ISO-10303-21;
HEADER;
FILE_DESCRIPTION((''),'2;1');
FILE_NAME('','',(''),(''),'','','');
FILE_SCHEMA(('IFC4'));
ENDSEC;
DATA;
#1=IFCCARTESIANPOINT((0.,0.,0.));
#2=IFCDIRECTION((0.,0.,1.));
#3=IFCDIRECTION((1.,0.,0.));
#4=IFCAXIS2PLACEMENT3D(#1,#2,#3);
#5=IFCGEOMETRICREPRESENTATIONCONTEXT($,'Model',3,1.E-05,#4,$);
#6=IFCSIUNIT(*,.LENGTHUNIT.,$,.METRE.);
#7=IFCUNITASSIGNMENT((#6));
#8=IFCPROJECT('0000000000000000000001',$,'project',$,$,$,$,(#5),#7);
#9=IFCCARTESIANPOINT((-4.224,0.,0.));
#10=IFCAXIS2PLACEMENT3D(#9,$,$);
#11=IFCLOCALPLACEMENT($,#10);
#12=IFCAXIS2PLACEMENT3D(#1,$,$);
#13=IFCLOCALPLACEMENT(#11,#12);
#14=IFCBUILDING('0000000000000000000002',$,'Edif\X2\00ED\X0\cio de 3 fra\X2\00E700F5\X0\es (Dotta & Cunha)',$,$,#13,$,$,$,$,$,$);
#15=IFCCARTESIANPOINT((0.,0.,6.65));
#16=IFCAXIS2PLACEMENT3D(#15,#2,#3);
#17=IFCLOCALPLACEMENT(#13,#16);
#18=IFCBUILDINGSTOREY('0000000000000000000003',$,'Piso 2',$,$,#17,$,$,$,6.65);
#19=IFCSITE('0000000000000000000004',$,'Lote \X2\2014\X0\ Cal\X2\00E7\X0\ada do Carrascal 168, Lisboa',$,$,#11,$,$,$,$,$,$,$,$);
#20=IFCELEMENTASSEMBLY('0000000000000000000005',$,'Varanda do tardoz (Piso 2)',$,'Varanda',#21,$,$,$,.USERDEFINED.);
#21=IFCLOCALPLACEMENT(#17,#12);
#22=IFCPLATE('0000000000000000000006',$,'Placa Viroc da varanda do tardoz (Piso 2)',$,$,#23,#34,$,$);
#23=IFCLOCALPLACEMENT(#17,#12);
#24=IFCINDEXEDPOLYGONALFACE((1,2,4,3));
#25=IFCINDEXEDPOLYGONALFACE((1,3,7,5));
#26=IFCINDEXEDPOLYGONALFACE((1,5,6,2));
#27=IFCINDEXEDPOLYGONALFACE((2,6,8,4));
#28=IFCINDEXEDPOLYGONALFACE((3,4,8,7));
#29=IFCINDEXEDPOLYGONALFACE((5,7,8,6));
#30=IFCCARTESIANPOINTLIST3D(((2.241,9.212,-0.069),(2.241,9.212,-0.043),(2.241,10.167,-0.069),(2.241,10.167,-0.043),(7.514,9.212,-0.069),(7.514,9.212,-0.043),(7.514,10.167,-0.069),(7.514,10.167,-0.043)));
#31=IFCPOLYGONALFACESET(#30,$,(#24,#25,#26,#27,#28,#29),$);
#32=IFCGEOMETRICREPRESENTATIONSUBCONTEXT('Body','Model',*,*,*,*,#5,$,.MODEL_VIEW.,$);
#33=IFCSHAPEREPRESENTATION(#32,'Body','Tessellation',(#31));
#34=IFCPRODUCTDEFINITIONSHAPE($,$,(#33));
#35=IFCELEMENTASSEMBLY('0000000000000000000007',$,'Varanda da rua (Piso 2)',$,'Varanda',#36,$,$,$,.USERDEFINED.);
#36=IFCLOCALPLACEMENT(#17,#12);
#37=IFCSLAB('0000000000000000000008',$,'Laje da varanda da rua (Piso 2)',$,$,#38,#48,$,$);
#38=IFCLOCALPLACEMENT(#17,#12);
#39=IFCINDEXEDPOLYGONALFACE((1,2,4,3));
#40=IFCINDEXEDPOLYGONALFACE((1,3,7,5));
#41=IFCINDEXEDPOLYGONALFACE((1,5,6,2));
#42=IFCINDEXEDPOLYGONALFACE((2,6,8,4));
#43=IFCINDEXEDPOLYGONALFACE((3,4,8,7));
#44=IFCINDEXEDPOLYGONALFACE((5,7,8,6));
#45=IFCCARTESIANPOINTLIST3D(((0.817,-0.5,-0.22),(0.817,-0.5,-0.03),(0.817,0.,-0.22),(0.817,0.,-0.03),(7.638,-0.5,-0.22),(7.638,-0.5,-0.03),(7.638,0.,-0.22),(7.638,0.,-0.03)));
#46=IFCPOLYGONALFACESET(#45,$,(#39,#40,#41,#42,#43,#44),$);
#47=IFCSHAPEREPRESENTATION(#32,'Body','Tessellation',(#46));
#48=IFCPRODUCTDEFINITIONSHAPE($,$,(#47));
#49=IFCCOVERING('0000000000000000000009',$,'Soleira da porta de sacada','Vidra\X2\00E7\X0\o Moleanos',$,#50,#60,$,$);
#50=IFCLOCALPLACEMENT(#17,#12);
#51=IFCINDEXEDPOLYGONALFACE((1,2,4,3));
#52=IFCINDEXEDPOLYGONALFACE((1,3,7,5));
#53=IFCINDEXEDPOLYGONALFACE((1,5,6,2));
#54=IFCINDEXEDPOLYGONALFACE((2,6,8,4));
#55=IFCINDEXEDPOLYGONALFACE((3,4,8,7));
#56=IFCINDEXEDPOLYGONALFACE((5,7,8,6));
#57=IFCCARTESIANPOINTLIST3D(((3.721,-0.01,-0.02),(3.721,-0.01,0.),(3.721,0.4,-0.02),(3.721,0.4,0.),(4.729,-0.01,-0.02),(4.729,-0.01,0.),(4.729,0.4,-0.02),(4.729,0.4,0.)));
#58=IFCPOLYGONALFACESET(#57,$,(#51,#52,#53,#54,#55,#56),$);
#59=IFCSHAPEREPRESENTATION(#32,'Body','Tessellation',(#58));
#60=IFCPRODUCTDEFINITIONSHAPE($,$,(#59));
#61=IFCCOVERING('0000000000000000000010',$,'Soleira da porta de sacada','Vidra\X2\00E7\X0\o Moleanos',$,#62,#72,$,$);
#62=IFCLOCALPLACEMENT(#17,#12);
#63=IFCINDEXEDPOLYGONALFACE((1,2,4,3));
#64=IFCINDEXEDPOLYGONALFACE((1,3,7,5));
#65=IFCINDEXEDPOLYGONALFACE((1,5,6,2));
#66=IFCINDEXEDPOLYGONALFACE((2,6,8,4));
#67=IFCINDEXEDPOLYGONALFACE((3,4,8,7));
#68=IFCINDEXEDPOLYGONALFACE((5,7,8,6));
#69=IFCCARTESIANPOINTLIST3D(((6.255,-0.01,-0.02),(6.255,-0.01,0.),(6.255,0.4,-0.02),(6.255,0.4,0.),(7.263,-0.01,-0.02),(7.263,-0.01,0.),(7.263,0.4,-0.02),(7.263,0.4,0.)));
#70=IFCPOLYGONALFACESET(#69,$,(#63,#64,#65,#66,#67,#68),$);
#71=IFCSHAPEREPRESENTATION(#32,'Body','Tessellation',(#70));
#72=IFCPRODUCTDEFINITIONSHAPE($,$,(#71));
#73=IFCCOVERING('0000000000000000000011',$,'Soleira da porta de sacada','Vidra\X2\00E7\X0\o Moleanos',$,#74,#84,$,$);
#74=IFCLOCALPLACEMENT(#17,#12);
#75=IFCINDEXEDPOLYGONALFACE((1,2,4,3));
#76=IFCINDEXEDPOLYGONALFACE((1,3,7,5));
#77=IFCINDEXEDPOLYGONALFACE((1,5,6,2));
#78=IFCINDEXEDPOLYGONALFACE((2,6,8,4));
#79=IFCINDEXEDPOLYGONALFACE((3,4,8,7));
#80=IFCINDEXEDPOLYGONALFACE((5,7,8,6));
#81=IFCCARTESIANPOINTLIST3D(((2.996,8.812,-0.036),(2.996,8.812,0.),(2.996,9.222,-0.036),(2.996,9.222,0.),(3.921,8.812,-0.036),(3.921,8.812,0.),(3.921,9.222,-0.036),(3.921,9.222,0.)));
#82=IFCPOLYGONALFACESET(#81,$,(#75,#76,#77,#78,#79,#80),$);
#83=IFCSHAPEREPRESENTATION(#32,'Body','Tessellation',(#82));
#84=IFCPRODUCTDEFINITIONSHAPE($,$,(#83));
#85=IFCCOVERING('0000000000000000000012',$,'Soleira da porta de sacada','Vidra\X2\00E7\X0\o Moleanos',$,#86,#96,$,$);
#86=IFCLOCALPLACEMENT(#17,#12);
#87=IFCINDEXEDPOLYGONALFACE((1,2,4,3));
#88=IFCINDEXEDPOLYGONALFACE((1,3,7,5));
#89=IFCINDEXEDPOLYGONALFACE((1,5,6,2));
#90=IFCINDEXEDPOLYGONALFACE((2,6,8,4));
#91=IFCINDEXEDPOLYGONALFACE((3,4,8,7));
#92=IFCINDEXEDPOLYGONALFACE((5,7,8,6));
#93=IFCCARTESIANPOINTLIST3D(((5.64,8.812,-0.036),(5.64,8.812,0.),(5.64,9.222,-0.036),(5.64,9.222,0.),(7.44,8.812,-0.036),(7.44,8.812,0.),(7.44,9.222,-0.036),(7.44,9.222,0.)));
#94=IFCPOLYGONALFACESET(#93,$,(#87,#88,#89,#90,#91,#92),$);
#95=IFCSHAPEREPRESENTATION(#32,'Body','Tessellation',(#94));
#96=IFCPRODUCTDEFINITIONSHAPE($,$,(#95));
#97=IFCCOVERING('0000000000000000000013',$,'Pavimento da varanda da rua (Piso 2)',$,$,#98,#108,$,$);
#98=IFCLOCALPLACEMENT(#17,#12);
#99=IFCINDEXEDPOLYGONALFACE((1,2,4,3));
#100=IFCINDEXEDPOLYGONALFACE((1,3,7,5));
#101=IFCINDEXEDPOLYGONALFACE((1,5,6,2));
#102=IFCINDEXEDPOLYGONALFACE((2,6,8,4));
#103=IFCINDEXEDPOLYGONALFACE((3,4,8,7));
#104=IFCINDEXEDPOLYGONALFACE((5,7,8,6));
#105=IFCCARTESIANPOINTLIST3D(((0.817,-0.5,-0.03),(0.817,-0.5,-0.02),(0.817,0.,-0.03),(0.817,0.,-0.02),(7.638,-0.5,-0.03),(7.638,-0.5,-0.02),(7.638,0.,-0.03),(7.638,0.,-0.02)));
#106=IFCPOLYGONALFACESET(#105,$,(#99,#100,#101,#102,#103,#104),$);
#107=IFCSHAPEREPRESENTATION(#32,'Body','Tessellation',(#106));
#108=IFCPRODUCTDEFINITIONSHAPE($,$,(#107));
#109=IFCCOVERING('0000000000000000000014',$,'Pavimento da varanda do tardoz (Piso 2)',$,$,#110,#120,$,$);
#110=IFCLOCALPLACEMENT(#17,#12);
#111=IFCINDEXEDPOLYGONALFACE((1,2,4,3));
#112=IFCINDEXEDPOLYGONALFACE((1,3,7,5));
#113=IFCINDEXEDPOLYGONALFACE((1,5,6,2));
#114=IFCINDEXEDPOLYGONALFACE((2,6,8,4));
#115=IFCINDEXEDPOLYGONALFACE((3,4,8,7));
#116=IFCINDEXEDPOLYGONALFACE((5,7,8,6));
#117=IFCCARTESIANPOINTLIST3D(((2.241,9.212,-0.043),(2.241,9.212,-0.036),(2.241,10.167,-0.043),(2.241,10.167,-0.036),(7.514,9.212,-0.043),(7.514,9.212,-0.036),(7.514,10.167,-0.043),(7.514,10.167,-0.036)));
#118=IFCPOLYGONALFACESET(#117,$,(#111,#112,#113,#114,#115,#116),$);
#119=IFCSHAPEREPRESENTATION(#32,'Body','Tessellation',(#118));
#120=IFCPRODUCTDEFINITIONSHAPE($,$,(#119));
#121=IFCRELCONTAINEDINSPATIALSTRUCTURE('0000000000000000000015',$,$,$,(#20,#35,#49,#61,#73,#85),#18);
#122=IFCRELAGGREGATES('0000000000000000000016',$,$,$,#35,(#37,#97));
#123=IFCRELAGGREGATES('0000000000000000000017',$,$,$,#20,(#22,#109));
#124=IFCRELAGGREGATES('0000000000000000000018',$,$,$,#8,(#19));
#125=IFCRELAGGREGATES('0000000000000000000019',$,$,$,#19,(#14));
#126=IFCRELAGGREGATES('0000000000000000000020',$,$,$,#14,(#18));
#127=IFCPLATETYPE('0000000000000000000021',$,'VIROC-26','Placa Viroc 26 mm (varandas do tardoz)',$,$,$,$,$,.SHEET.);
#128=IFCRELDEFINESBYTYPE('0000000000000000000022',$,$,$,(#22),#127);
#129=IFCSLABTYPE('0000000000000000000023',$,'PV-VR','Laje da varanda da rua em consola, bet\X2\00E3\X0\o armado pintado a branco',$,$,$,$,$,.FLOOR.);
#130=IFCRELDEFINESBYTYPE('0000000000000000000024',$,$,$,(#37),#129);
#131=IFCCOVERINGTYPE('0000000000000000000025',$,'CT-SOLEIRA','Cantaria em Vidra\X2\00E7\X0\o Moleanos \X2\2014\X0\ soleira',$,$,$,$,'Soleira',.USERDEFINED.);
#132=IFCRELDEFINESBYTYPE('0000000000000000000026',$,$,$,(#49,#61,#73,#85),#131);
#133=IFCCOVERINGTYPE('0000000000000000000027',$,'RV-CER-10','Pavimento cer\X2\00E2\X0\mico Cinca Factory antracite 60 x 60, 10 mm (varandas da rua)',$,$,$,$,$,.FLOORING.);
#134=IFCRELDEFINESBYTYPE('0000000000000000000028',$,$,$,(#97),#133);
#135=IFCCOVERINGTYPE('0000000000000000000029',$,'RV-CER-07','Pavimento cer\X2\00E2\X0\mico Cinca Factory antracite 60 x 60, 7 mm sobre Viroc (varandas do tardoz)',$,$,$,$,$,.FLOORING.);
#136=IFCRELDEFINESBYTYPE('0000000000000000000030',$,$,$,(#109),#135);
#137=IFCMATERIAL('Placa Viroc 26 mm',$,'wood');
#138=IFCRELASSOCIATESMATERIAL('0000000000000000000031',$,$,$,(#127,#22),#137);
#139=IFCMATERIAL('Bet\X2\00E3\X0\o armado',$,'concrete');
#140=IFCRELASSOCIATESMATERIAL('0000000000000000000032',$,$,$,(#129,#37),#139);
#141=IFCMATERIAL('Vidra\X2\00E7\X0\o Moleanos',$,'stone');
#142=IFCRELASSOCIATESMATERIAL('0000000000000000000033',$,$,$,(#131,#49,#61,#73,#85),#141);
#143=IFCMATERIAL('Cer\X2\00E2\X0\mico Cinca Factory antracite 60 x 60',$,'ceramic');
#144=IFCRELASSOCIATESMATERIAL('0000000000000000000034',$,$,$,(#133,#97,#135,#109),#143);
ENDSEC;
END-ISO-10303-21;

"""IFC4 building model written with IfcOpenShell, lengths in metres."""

from ifc_helpers import new_model, si_unit, frame, origin, origin_with_axes, place, context, subcontext, project, spatial, line, indexed_curve, outline, extrude, material, type_object, element, aggregate, save


model = new_model("IFC4")

# Units and contexts
model_context = context("Model", 3, precision=1e-05, world=origin_with_axes())
body_context = subcontext(model_context, "Body", "Model", "MODEL_VIEW")
ifc_project = project(units=[si_unit("LENGTHUNIT", "METRE")], contexts=[model_context])

# Site, building, storey
site_placement = place(None, frame((-4.224, 0.0, 0.0)))
site = spatial("IfcSite", under=ifc_project, at=site_placement, Name="Lote — Calçada do Carrascal 168, Lisboa")
building_placement = place(site_placement, origin())
building = spatial("IfcBuilding", under=site, at=building_placement, Name="Edifício de 3 frações (Dotta & Cunha)")
storey_placement = place(building_placement, frame((0.0, 0.0, 6.65), z_axis=(0.0, 0.0, 1.0), x_axis=(1.0, 0.0, 0.0)))
storey = spatial("IfcBuildingStorey", under=building, at=storey_placement, Name="Piso 2", Elevation=6.65)

# Element assembly, plate
assembly_1 = element("IfcElementAssembly", 1, inside=storey, Name="Varanda do tardoz (Piso 2)", ObjectType="Varanda", PredefinedType="USERDEFINED")
ifc_material_1 = material(Name="Placa Viroc 26 mm", Category="wood")
plate_type = type_object("IfcPlateType", Name="VIROC-26", Description="Placa Viroc 26 mm (varandas do tardoz)", PredefinedType="SHEET", material=ifc_material_1)
plate_placement = place(building_placement, frame((0.0, 0.0, 6.581), z_axis=(0.0, 0.0, 1.0), x_axis=(1.0, 0.0, 0.0)))
plate = element("IfcPlate", 2, at=plate_placement, type_object=plate_type, material=ifc_material_1, Name="Placa Viroc da varanda do tardoz (Piso 2)", context=body_context, shape_type="SweptSolid", body=[
    extrude(outline(indexed_curve([(7.514, 9.212), (7.514, 10.167), (2.241, 10.167), (2.241, 9.212)], segments=[line(1, 2, 3, 4, 1)])), origin_with_axes(), (0.0, 0.0, 1.0), 0.026),
])

# Element assembly, slab
assembly_2 = element("IfcElementAssembly", 3, inside=storey, Name="Varanda da rua (Piso 2)", ObjectType="Varanda", PredefinedType="USERDEFINED")
ifc_material_2 = material(Name="Betão armado", Category="concrete")
slab_type = type_object("IfcSlabType", Name="PV-VR", Description="Laje da varanda da rua em consola, betão armado pintado a branco", PredefinedType="FLOOR", material=ifc_material_2)
slab_placement = place(building_placement, frame((0.0, 0.0, 6.43), z_axis=(0.0, 0.0, 1.0), x_axis=(1.0, 0.0, 0.0)))
slab = element("IfcSlab", 4, at=slab_placement, type_object=slab_type, material=ifc_material_2, Name="Laje da varanda da rua (Piso 2)", context=body_context, shape_type="SweptSolid", body=[
    extrude(outline(indexed_curve([(7.638, -0.5), (7.638, 0.0), (0.817, 0.0), (0.817, -0.5)], segments=[line(1, 2, 3, 4, 1)])), origin_with_axes(), (0.0, 0.0, 1.0), 0.19),
])

# Coverings
ifc_material_3 = material(Name="Vidraço Moleanos", Category="stone")
covering_type_1 = type_object("IfcCoveringType", Name="CT-SOLEIRA", Description="Cantaria em Vidraço Moleanos — soleira", ElementType="Soleira", PredefinedType="USERDEFINED", material=ifc_material_3)
covering_1_placement = place(storey_placement, frame((0.0, 0.0, -0.02), z_axis=(0.0, 0.0, 1.0), x_axis=(1.0, 0.0, 0.0)))
element("IfcCovering", 5, at=covering_1_placement, inside=storey, type_object=covering_type_1, material=ifc_material_3, Name="Soleira da porta de sacada", Description="Vidraço Moleanos", context=body_context, shape_type="SweptSolid", body=[
    extrude(outline(indexed_curve([(4.729, -0.01), (4.729, 0.4), (3.721, 0.4), (3.721, -0.01)], segments=[line(1, 2, 3, 4, 1)])), origin_with_axes(), (0.0, 0.0, 1.0), 0.02),
])
covering_2_placement = place(storey_placement, frame((0.0, 0.0, -0.02), z_axis=(0.0, 0.0, 1.0), x_axis=(1.0, 0.0, 0.0)))
element("IfcCovering", 6, at=covering_2_placement, inside=storey, type_object=covering_type_1, material=ifc_material_3, Name="Soleira da porta de sacada", Description="Vidraço Moleanos", context=body_context, shape_type="SweptSolid", body=[
    extrude(outline(indexed_curve([(7.263, -0.01), (7.263, 0.4), (6.255, 0.4), (6.255, -0.01)], segments=[line(1, 2, 3, 4, 1)])), origin_with_axes(), (0.0, 0.0, 1.0), 0.02),
])
covering_3_placement = place(storey_placement, frame((0.0, 0.0, -0.036), z_axis=(0.0, 0.0, 1.0), x_axis=(1.0, 0.0, 0.0)))
element("IfcCovering", 7, at=covering_3_placement, inside=storey, type_object=covering_type_1, material=ifc_material_3, Name="Soleira da porta de sacada", Description="Vidraço Moleanos", context=body_context, shape_type="SweptSolid", body=[
    extrude(outline(indexed_curve([(3.921, 8.812), (3.921, 9.222), (2.996, 9.222), (2.996, 8.812)], segments=[line(1, 2, 3, 4, 1)])), origin_with_axes(), (0.0, 0.0, 1.0), 0.036),
])
covering_4_placement = place(storey_placement, frame((0.0, 0.0, -0.036), z_axis=(0.0, 0.0, 1.0), x_axis=(1.0, 0.0, 0.0)))
element("IfcCovering", 8, at=covering_4_placement, inside=storey, type_object=covering_type_1, material=ifc_material_3, Name="Soleira da porta de sacada", Description="Vidraço Moleanos", context=body_context, shape_type="SweptSolid", body=[
    extrude(outline(indexed_curve([(7.44, 8.812), (7.44, 9.222), (5.64, 9.222), (5.64, 8.812)], segments=[line(1, 2, 3, 4, 1)])), origin_with_axes(), (0.0, 0.0, 1.0), 0.036),
])

# Coverings
ifc_material_4 = material(Name="Cerâmico Cinca Factory antracite 60 x 60", Category="ceramic")
covering_type_2 = type_object("IfcCoveringType", Name="RV-CER-10", Description="Pavimento cerâmico Cinca Factory antracite 60 x 60, 10 mm (varandas da rua)", PredefinedType="FLOORING", material=ifc_material_4)
covering_5_placement = place(building_placement, frame((0.0, 0.0, 6.62), z_axis=(0.0, 0.0, 1.0), x_axis=(1.0, 0.0, 0.0)))
covering_5 = element("IfcCovering", 9, at=covering_5_placement, type_object=covering_type_2, material=ifc_material_4, Name="Pavimento da varanda da rua (Piso 2)", context=body_context, shape_type="SweptSolid", body=[
    extrude(outline(indexed_curve([(7.638, -0.5), (7.638, 0.0), (0.817, 0.0), (0.817, -0.5)], segments=[line(1, 2, 3, 4, 1)])), origin_with_axes(), (0.0, 0.0, 1.0), 0.01),
])
aggregate(assembly_2, [slab, covering_5])
covering_type_3 = type_object("IfcCoveringType", Name="RV-CER-07", Description="Pavimento cerâmico Cinca Factory antracite 60 x 60, 7 mm sobre Viroc (varandas do tardoz)", PredefinedType="FLOORING", material=ifc_material_4)
covering_6_placement = place(building_placement, frame((0.0, 0.0, 6.607), z_axis=(0.0, 0.0, 1.0), x_axis=(1.0, 0.0, 0.0)))
covering_6 = element("IfcCovering", 10, at=covering_6_placement, type_object=covering_type_3, material=ifc_material_4, Name="Pavimento da varanda do tardoz (Piso 2)", context=body_context, shape_type="SweptSolid", body=[
    extrude(outline(indexed_curve([(7.514, 9.212), (7.514, 10.167), (2.241, 10.167), (2.241, 9.212)], segments=[line(1, 2, 3, 4, 1)])), origin_with_axes(), (0.0, 0.0, 1.0), 0.007),
])
aggregate(assembly_1, [plate, covering_6])

save(model, "model.ifc")
